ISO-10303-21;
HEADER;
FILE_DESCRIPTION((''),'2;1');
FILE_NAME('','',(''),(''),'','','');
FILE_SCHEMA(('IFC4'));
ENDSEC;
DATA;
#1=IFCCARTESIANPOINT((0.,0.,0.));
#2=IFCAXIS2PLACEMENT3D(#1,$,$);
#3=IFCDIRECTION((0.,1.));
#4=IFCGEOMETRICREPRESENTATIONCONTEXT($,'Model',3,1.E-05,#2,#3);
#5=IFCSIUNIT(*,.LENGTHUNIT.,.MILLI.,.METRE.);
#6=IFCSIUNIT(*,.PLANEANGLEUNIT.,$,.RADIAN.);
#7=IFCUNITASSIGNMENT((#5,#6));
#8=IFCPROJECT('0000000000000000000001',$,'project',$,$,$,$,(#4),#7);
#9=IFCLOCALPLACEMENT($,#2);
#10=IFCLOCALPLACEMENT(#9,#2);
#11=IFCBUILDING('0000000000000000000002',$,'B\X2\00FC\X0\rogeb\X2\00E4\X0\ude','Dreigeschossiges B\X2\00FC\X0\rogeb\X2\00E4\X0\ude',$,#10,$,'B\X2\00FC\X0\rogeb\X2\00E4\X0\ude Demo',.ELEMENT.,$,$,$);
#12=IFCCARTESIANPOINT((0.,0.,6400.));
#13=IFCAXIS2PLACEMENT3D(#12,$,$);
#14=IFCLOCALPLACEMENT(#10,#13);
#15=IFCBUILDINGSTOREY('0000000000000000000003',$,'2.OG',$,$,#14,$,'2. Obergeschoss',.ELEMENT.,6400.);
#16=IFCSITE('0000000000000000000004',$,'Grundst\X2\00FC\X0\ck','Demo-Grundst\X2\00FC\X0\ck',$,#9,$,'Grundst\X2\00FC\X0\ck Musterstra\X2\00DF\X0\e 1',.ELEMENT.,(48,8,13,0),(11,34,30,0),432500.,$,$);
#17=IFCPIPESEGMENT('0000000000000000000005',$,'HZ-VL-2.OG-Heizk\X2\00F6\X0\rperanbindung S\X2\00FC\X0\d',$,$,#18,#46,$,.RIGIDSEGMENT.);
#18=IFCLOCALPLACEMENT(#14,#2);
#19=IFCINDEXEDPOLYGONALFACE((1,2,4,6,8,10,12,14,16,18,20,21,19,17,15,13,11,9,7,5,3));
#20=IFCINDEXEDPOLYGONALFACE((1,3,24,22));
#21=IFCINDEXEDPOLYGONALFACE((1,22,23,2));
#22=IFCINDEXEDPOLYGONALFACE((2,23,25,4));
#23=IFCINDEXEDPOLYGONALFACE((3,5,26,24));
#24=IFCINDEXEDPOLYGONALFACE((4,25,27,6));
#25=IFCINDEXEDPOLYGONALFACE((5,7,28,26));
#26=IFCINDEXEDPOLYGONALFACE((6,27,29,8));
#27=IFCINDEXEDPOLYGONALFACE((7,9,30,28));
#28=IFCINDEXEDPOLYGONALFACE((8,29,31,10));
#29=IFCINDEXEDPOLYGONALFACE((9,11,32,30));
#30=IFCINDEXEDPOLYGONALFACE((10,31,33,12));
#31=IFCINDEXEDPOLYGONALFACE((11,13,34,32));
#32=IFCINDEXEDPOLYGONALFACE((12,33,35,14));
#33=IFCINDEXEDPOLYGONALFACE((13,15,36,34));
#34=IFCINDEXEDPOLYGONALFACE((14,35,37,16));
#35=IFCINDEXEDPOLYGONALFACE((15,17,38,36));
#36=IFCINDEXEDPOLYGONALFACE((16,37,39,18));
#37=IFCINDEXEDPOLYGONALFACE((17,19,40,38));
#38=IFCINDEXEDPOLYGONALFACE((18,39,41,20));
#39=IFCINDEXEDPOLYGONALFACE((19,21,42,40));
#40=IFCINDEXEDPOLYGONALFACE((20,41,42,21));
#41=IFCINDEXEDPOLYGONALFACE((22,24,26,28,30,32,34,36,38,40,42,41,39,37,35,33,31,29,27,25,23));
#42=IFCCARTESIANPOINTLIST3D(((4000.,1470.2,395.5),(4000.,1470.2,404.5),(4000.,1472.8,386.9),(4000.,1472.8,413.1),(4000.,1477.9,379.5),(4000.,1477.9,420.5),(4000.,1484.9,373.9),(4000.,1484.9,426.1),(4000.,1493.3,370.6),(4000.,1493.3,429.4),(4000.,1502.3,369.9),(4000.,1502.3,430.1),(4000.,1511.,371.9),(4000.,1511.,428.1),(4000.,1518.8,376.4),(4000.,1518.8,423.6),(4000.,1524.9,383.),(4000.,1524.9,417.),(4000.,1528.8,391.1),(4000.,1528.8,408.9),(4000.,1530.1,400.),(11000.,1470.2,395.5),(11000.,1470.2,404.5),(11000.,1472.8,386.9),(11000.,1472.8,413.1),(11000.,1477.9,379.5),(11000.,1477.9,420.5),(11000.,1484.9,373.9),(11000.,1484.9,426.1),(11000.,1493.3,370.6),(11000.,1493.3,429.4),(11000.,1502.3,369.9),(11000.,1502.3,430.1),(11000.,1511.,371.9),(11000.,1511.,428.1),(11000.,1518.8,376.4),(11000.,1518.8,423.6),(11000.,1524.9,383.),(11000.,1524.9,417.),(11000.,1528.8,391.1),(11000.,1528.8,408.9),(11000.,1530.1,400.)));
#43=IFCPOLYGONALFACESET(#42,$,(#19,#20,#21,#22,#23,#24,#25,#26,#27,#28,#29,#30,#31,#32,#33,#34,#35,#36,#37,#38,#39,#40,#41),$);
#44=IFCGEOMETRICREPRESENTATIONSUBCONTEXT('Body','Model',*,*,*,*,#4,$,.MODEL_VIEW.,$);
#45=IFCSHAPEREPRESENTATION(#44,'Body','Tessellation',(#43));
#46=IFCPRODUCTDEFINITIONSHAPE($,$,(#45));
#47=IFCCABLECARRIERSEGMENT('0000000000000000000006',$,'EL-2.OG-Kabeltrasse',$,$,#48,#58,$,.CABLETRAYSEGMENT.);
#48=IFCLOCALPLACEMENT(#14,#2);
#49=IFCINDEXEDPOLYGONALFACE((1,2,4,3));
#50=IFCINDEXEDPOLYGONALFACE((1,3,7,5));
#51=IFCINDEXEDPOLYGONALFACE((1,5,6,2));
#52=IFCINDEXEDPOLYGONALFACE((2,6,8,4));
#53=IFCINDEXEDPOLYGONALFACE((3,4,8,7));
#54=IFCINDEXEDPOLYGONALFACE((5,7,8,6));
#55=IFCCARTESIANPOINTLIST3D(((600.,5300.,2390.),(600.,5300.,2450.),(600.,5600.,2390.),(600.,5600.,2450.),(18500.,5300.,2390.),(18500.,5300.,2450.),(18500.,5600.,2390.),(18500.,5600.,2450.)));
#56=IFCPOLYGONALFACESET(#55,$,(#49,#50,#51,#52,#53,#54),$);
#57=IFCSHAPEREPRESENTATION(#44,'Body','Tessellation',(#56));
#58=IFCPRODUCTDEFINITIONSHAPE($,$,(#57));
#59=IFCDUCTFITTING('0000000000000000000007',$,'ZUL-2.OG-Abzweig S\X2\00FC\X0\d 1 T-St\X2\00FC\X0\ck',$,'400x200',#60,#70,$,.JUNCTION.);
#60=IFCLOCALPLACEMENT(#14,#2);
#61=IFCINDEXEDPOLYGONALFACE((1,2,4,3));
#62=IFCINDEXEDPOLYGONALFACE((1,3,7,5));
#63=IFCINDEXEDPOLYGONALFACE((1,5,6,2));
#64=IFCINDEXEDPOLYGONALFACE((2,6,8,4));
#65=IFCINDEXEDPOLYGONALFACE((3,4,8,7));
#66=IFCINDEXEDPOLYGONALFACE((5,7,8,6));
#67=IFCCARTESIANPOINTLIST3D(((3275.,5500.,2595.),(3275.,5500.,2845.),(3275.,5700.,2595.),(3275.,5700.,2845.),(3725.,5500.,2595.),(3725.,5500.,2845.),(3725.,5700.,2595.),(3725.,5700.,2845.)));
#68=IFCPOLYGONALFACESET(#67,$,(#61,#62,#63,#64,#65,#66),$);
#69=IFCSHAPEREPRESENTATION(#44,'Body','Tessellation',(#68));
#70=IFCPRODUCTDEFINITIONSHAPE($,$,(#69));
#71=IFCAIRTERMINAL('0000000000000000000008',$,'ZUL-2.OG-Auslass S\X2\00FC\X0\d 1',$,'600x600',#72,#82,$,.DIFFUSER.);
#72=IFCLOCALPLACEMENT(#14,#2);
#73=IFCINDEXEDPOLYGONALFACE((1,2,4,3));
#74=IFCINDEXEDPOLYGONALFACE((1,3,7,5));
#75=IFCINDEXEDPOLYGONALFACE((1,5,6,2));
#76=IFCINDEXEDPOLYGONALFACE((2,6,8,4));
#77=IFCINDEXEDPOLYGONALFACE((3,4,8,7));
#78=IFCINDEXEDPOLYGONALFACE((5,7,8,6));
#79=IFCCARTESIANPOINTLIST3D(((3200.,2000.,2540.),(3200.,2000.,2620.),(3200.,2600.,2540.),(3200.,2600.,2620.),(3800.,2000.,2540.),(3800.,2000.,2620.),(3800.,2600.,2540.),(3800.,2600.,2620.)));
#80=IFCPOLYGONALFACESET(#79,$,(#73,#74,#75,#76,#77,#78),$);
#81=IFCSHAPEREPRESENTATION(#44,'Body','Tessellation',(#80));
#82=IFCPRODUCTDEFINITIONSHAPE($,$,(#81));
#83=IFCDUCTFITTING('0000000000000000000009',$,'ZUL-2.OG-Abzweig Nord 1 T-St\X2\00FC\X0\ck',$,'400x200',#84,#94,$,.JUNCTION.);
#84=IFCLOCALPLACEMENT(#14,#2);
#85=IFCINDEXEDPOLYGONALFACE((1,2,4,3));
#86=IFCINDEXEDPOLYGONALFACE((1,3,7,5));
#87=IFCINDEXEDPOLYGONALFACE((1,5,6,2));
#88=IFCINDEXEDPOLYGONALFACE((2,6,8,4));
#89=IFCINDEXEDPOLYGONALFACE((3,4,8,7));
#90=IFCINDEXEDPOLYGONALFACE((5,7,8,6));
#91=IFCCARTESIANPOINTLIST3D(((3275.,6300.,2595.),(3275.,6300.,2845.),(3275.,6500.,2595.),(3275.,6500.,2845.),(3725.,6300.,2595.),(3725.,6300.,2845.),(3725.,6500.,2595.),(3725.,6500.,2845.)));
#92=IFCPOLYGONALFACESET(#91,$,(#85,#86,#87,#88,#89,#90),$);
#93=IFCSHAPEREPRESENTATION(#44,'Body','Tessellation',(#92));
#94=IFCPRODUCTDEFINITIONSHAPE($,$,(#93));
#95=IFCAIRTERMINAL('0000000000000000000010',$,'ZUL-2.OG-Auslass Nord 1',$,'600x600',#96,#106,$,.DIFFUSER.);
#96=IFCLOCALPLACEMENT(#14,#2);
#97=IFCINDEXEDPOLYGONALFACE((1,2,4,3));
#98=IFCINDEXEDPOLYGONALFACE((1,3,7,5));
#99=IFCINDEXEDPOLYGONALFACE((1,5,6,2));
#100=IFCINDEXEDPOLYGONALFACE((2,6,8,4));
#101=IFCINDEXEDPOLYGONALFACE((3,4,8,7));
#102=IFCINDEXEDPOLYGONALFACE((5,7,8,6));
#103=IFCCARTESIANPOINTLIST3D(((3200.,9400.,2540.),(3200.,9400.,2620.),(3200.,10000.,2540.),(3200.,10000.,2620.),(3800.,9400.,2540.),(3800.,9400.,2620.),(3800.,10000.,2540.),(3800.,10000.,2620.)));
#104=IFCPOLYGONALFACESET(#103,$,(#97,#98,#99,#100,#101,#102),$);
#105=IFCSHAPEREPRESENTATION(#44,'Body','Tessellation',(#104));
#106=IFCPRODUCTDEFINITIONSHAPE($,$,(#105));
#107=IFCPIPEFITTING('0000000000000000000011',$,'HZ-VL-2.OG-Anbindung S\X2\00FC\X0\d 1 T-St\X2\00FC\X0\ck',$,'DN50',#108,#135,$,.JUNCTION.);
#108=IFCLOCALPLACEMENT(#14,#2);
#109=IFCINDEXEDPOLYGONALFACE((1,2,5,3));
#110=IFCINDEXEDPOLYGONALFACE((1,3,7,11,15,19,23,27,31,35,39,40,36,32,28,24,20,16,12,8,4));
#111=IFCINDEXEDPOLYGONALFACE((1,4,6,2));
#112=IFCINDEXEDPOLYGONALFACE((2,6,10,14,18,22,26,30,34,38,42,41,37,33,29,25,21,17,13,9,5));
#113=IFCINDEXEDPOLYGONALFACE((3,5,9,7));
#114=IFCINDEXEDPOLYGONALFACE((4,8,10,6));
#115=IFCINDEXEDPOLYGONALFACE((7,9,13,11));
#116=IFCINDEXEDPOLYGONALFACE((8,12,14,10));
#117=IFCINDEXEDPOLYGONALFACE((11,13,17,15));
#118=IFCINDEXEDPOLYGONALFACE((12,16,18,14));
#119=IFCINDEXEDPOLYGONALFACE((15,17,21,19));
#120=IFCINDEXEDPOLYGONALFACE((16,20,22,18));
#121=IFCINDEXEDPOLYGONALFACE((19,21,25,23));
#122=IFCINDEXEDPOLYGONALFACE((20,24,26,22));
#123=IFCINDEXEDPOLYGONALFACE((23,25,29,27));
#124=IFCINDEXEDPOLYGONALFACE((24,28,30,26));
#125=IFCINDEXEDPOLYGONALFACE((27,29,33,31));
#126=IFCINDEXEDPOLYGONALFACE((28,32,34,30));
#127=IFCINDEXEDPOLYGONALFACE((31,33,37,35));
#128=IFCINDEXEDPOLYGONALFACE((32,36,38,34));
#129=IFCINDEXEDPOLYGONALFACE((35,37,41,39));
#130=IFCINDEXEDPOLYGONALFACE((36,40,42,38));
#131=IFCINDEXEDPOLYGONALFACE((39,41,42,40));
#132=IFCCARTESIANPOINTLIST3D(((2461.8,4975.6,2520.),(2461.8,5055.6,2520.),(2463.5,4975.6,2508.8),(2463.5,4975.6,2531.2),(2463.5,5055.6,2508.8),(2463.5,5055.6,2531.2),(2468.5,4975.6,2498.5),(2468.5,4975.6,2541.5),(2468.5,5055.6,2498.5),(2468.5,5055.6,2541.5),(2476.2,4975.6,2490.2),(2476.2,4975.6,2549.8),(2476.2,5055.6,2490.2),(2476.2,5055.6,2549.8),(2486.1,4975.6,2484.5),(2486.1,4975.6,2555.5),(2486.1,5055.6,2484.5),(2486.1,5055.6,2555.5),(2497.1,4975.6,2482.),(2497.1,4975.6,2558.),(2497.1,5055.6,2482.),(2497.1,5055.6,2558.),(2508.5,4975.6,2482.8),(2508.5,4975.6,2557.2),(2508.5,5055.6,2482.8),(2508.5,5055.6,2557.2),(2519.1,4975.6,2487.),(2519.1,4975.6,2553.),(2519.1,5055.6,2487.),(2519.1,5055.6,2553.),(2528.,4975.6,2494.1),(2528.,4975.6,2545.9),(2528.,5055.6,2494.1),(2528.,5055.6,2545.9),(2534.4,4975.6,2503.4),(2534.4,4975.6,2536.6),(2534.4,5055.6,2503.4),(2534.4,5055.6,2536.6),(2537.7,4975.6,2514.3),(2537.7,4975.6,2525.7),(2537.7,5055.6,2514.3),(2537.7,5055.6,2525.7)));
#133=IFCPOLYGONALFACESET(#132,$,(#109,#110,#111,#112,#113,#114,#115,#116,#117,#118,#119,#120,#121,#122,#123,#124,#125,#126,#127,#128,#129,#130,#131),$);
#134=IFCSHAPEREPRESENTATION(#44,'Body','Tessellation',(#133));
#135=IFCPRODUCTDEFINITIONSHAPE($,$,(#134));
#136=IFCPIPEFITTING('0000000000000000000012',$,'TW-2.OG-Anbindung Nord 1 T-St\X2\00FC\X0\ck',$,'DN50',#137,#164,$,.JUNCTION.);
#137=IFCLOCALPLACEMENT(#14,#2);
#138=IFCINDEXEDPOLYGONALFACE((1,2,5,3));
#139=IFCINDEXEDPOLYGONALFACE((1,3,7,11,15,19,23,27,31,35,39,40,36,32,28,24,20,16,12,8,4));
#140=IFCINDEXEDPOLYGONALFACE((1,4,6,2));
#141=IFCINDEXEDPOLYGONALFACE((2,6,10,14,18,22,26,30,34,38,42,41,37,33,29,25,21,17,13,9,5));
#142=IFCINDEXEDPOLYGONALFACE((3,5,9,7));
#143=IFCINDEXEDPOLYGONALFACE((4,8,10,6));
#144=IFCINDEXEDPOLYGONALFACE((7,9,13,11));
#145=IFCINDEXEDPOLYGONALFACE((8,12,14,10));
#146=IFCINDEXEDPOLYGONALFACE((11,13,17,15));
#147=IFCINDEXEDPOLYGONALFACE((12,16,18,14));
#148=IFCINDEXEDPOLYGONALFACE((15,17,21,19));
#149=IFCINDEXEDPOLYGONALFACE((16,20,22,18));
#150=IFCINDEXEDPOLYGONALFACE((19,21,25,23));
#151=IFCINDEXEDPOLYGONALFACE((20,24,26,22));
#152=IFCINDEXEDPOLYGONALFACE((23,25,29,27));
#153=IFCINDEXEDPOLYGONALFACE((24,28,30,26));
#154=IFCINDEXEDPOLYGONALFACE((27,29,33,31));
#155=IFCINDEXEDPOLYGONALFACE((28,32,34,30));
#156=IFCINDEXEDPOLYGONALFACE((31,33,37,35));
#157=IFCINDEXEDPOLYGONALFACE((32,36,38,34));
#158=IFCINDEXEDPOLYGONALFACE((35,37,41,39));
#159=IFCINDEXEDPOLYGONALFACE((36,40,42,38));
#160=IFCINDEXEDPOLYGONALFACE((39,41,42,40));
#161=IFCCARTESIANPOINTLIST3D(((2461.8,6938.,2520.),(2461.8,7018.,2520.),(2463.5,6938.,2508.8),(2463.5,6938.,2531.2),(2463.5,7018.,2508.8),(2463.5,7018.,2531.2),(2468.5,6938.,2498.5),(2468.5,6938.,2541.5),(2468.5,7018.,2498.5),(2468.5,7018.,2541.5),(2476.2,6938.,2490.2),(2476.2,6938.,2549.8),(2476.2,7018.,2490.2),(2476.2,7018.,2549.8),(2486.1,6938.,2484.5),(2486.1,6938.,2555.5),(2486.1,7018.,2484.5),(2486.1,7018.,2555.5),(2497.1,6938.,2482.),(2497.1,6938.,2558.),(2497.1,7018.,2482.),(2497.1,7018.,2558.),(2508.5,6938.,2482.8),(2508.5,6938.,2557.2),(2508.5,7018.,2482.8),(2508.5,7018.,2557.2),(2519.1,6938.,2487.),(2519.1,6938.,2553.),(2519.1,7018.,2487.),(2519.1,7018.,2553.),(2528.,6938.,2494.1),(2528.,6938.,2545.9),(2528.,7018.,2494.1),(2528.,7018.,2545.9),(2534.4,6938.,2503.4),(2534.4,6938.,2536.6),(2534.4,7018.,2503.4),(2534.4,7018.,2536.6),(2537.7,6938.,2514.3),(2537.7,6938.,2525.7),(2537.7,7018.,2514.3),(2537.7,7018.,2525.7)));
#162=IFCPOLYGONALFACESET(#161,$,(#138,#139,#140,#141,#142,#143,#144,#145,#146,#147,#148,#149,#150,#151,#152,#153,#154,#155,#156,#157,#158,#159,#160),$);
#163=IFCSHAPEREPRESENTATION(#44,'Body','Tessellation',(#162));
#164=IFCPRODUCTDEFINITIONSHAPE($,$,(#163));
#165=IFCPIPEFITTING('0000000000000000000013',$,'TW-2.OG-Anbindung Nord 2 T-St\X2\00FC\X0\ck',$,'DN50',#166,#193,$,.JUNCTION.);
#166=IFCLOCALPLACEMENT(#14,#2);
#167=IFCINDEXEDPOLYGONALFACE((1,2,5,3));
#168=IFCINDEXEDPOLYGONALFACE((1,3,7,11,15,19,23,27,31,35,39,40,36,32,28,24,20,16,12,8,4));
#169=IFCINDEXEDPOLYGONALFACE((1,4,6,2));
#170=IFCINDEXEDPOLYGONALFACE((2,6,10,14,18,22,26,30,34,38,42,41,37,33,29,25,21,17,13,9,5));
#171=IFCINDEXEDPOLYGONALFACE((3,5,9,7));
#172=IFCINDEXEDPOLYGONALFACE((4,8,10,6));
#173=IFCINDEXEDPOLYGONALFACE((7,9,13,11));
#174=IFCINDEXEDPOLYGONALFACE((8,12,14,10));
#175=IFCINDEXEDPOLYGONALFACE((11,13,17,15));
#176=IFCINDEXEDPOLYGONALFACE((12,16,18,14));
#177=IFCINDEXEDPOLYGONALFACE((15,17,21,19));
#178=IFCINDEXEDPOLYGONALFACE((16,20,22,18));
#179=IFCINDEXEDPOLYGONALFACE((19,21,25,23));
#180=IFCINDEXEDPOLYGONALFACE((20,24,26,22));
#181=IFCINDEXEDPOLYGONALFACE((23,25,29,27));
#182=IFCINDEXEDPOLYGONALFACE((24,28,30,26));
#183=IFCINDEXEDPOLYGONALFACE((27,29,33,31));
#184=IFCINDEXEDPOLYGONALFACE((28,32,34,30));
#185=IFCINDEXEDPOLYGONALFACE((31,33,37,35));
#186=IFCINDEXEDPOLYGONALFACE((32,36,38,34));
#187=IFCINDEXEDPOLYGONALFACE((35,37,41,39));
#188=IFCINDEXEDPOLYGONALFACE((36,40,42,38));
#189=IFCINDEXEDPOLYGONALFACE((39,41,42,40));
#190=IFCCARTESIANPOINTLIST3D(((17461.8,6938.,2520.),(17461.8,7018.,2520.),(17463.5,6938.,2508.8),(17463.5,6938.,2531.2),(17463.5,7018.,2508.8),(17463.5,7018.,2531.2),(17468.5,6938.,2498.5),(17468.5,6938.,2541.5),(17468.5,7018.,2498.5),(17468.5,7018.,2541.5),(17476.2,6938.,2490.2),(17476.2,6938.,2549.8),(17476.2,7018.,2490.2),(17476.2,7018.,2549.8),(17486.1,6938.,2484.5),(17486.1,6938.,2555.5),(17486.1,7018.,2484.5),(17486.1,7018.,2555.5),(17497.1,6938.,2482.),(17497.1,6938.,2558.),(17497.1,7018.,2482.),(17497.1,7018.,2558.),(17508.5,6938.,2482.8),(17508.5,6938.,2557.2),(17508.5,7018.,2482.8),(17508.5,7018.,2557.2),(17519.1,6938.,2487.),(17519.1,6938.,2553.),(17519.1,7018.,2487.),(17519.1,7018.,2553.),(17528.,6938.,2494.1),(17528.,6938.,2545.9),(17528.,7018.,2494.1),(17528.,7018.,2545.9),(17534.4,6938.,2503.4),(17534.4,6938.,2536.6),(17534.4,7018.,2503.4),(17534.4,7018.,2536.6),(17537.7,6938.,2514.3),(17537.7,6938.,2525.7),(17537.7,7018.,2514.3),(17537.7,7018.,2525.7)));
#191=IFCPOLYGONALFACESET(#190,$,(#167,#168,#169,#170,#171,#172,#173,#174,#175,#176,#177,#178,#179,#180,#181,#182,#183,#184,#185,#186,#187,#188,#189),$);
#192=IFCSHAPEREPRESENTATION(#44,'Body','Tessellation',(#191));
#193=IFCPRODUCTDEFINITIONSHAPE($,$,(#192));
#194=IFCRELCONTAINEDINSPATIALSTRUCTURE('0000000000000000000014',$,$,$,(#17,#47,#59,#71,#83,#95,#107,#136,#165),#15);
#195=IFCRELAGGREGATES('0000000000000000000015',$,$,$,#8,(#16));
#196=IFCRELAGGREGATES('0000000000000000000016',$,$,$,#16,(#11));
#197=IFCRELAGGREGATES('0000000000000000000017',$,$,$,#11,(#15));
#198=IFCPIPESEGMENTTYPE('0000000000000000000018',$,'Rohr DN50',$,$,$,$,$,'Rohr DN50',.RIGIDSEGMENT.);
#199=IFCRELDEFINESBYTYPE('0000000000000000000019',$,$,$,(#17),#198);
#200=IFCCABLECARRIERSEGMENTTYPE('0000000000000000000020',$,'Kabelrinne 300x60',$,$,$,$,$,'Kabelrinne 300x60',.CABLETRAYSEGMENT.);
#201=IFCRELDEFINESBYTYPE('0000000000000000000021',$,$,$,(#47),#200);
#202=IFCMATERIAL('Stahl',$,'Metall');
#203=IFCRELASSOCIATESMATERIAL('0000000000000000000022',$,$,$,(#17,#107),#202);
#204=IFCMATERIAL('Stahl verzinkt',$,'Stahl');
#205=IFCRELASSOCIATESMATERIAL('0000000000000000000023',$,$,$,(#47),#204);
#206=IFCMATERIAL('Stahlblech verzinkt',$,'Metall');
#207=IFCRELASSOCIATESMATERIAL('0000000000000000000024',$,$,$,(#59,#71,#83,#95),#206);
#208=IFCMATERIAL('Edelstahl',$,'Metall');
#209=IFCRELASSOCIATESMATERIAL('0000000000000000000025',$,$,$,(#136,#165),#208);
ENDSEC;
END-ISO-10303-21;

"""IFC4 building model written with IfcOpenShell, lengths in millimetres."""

from ifc_helpers import new_model, si_unit, direction, frame, origin, origin_2d, place, context, subcontext, project, spatial, rectangle, circle, extrude, material, type_object, element, save


model = new_model("IFC4")

# Units and contexts
model_context = context("Model", 3, precision=1e-05, world=origin(), true_north=direction((0.0, 1.0)))
body_context = subcontext(model_context, "Body", "Model", "MODEL_VIEW")
ifc_project = project(units=[si_unit("LENGTHUNIT", "METRE", prefix="MILLI"), si_unit("PLANEANGLEUNIT", "RADIAN")], contexts=[model_context])

# Site, building, storey
site_placement = place(None, origin())
site = spatial("IfcSite", under=ifc_project, at=site_placement, Name="Grundstück", Description="Demo-Grundstück", LongName="Grundstück Musterstraße 1", CompositionType="ELEMENT", RefLatitude=(48, 8, 13, 0), RefLongitude=(11, 34, 30, 0), RefElevation=432500.0)
building_placement = place(site_placement, origin())
building = spatial("IfcBuilding", under=site, at=building_placement, Name="Bürogebäude", Description="Dreigeschossiges Bürogebäude", LongName="Bürogebäude Demo", CompositionType="ELEMENT")
storey_placement = place(building_placement, frame((0.0, 0.0, 6400.0)))
storey = spatial("IfcBuildingStorey", under=building, at=storey_placement, Name="2.OG", LongName="2. Obergeschoss", CompositionType="ELEMENT", Elevation=6400.0)

# Shared definitions
ifc_material_1 = material(Name="Stahlblech verzinkt", Category="Metall")

# Pipe segment
ifc_material_2 = material(Name="Stahl", Category="Metall")
ifc_material_3 = material(Name="Edelstahl", Category="Metall")
pipe_segment_type_1 = type_object("IfcPipeSegmentType", Name="Rohr DN50", ElementType="Rohr DN50", PredefinedType="RIGIDSEGMENT")
pipe_segment_1_placement = place(storey_placement, frame((4000.0, 1500.0, 400.0)))
element("IfcPipeSegment", 1, at=pipe_segment_1_placement, inside=storey, type_object=pipe_segment_type_1, material=ifc_material_2, Name="HZ-VL-2.OG-Heizkörperanbindung Süd", PredefinedType="RIGIDSEGMENT", context=body_context, shape_type="SweptSolid", body=[
    extrude(circle(Radius=30.1, at=origin_2d()), frame((0.0, 0.0, 0.0), z_axis=(1.0, 0.0, 0.0), x_axis=(0.0, 1.0, 0.0)), (0.0, 0.0, 1.0), 7000.0),
])

# Cable carrier segment
ifc_material_4 = material(Name="Stahl verzinkt", Category="Stahl")
cable_carrier_segment_type = type_object("IfcCableCarrierSegmentType", Name="Kabelrinne 300x60", ElementType="Kabelrinne 300x60", PredefinedType="CABLETRAYSEGMENT")
cable_carrier_segment_placement = place(storey_placement, frame((600.0, 5450.0, 2420.0)))
element("IfcCableCarrierSegment", 2, at=cable_carrier_segment_placement, inside=storey, type_object=cable_carrier_segment_type, material=ifc_material_4, Name="EL-2.OG-Kabeltrasse", PredefinedType="CABLETRAYSEGMENT", context=body_context, shape_type="SweptSolid", body=[
    extrude(rectangle(XDim=300.0, YDim=60.0, at=origin_2d()), frame((0.0, 0.0, 0.0), z_axis=(1.0, 0.0, 0.0), x_axis=(0.0, 1.0, 0.0)), (0.0, 0.0, 1.0), 17900.0),
])

# Duct fitting
duct_fitting_1_placement = place(storey_placement, frame((3500.0, 5500.0, 2720.0)))
element("IfcDuctFitting", 3, at=duct_fitting_1_placement, inside=storey, material=ifc_material_1, Name="ZUL-2.OG-Abzweig Süd 1 T-Stück", ObjectType="400x200", PredefinedType="JUNCTION", context=body_context, shape_type="SweptSolid", body=[
    extrude(rectangle(XDim=450.0, YDim=250.0, at=origin_2d()), frame((0.0, 0.0, 0.0), z_axis=(0.0, 1.0, 0.0), x_axis=(-1.0, 0.0, 0.0)), (0.0, 0.0, 1.0), 200.0),
])

# Air terminal
air_terminal_1_placement = place(storey_placement, frame((3500.0, 2300.0, 2540.0)))
element("IfcAirTerminal", 4, at=air_terminal_1_placement, inside=storey, material=ifc_material_1, Name="ZUL-2.OG-Auslass Süd 1", ObjectType="600x600", PredefinedType="DIFFUSER", context=body_context, shape_type="SweptSolid", body=[
    extrude(rectangle(XDim=600.0, YDim=600.0, at=origin_2d()), origin(), (0.0, 0.0, 1.0), 80.0),
])

# Duct fitting
duct_fitting_2_placement = place(storey_placement, frame((3500.0, 6300.0, 2720.0)))
element("IfcDuctFitting", 5, at=duct_fitting_2_placement, inside=storey, material=ifc_material_1, Name="ZUL-2.OG-Abzweig Nord 1 T-Stück", ObjectType="400x200", PredefinedType="JUNCTION", context=body_context, shape_type="SweptSolid", body=[
    extrude(rectangle(XDim=450.0, YDim=250.0, at=origin_2d()), frame((0.0, 0.0, 0.0), z_axis=(0.0, 1.0, 0.0), x_axis=(-1.0, 0.0, 0.0)), (0.0, 0.0, 1.0), 200.0),
])

# Air terminal
air_terminal_2_placement = place(storey_placement, frame((3500.0, 9700.0, 2540.0)))
element("IfcAirTerminal", 6, at=air_terminal_2_placement, inside=storey, material=ifc_material_1, Name="ZUL-2.OG-Auslass Nord 1", ObjectType="600x600", PredefinedType="DIFFUSER", context=body_context, shape_type="SweptSolid", body=[
    extrude(rectangle(XDim=600.0, YDim=600.0, at=origin_2d()), origin(), (0.0, 0.0, 1.0), 80.0),
])

# Pipe fittings
pipe_fitting_placement = place(storey_placement, frame((2500.0, 4975.6, 2520.0)))
element("IfcPipeFitting", 7, at=pipe_fitting_placement, inside=storey, material=ifc_material_2, Name="HZ-VL-2.OG-Anbindung Süd 1 T-Stück", ObjectType="DN50", PredefinedType="JUNCTION", context=body_context, shape_type="SweptSolid", body=[
    extrude(circle(Radius=38.1, at=origin_2d()), frame((0.0, 0.0, 0.0), z_axis=(0.0, 1.0, 0.0), x_axis=(-1.0, 0.0, 0.0)), (0.0, 0.0, 1.0), 80.0),
])
for number, where, name in (
    (8, (2500.0, 6938.1, 2520.0), "TW-2.OG-Anbindung Nord 1 T-Stück"),
    (9, (17500.0, 6938.1, 2520.0), "TW-2.OG-Anbindung Nord 2 T-Stück"),
):
    element("IfcPipeFitting", number, at=place(storey_placement, frame(where)), inside=storey, material=ifc_material_3, Name=name, ObjectType="DN50", PredefinedType="JUNCTION", context=body_context, shape_type="SweptSolid", body=[
        extrude(circle(Radius=38.1, at=origin_2d()), frame((0.0, 0.0, 0.0), z_axis=(0.0, 1.0, 0.0), x_axis=(-1.0, 0.0, 0.0)), (0.0, 0.0, 1.0), 80.0),
    ])

save(model, "model.ifc")
